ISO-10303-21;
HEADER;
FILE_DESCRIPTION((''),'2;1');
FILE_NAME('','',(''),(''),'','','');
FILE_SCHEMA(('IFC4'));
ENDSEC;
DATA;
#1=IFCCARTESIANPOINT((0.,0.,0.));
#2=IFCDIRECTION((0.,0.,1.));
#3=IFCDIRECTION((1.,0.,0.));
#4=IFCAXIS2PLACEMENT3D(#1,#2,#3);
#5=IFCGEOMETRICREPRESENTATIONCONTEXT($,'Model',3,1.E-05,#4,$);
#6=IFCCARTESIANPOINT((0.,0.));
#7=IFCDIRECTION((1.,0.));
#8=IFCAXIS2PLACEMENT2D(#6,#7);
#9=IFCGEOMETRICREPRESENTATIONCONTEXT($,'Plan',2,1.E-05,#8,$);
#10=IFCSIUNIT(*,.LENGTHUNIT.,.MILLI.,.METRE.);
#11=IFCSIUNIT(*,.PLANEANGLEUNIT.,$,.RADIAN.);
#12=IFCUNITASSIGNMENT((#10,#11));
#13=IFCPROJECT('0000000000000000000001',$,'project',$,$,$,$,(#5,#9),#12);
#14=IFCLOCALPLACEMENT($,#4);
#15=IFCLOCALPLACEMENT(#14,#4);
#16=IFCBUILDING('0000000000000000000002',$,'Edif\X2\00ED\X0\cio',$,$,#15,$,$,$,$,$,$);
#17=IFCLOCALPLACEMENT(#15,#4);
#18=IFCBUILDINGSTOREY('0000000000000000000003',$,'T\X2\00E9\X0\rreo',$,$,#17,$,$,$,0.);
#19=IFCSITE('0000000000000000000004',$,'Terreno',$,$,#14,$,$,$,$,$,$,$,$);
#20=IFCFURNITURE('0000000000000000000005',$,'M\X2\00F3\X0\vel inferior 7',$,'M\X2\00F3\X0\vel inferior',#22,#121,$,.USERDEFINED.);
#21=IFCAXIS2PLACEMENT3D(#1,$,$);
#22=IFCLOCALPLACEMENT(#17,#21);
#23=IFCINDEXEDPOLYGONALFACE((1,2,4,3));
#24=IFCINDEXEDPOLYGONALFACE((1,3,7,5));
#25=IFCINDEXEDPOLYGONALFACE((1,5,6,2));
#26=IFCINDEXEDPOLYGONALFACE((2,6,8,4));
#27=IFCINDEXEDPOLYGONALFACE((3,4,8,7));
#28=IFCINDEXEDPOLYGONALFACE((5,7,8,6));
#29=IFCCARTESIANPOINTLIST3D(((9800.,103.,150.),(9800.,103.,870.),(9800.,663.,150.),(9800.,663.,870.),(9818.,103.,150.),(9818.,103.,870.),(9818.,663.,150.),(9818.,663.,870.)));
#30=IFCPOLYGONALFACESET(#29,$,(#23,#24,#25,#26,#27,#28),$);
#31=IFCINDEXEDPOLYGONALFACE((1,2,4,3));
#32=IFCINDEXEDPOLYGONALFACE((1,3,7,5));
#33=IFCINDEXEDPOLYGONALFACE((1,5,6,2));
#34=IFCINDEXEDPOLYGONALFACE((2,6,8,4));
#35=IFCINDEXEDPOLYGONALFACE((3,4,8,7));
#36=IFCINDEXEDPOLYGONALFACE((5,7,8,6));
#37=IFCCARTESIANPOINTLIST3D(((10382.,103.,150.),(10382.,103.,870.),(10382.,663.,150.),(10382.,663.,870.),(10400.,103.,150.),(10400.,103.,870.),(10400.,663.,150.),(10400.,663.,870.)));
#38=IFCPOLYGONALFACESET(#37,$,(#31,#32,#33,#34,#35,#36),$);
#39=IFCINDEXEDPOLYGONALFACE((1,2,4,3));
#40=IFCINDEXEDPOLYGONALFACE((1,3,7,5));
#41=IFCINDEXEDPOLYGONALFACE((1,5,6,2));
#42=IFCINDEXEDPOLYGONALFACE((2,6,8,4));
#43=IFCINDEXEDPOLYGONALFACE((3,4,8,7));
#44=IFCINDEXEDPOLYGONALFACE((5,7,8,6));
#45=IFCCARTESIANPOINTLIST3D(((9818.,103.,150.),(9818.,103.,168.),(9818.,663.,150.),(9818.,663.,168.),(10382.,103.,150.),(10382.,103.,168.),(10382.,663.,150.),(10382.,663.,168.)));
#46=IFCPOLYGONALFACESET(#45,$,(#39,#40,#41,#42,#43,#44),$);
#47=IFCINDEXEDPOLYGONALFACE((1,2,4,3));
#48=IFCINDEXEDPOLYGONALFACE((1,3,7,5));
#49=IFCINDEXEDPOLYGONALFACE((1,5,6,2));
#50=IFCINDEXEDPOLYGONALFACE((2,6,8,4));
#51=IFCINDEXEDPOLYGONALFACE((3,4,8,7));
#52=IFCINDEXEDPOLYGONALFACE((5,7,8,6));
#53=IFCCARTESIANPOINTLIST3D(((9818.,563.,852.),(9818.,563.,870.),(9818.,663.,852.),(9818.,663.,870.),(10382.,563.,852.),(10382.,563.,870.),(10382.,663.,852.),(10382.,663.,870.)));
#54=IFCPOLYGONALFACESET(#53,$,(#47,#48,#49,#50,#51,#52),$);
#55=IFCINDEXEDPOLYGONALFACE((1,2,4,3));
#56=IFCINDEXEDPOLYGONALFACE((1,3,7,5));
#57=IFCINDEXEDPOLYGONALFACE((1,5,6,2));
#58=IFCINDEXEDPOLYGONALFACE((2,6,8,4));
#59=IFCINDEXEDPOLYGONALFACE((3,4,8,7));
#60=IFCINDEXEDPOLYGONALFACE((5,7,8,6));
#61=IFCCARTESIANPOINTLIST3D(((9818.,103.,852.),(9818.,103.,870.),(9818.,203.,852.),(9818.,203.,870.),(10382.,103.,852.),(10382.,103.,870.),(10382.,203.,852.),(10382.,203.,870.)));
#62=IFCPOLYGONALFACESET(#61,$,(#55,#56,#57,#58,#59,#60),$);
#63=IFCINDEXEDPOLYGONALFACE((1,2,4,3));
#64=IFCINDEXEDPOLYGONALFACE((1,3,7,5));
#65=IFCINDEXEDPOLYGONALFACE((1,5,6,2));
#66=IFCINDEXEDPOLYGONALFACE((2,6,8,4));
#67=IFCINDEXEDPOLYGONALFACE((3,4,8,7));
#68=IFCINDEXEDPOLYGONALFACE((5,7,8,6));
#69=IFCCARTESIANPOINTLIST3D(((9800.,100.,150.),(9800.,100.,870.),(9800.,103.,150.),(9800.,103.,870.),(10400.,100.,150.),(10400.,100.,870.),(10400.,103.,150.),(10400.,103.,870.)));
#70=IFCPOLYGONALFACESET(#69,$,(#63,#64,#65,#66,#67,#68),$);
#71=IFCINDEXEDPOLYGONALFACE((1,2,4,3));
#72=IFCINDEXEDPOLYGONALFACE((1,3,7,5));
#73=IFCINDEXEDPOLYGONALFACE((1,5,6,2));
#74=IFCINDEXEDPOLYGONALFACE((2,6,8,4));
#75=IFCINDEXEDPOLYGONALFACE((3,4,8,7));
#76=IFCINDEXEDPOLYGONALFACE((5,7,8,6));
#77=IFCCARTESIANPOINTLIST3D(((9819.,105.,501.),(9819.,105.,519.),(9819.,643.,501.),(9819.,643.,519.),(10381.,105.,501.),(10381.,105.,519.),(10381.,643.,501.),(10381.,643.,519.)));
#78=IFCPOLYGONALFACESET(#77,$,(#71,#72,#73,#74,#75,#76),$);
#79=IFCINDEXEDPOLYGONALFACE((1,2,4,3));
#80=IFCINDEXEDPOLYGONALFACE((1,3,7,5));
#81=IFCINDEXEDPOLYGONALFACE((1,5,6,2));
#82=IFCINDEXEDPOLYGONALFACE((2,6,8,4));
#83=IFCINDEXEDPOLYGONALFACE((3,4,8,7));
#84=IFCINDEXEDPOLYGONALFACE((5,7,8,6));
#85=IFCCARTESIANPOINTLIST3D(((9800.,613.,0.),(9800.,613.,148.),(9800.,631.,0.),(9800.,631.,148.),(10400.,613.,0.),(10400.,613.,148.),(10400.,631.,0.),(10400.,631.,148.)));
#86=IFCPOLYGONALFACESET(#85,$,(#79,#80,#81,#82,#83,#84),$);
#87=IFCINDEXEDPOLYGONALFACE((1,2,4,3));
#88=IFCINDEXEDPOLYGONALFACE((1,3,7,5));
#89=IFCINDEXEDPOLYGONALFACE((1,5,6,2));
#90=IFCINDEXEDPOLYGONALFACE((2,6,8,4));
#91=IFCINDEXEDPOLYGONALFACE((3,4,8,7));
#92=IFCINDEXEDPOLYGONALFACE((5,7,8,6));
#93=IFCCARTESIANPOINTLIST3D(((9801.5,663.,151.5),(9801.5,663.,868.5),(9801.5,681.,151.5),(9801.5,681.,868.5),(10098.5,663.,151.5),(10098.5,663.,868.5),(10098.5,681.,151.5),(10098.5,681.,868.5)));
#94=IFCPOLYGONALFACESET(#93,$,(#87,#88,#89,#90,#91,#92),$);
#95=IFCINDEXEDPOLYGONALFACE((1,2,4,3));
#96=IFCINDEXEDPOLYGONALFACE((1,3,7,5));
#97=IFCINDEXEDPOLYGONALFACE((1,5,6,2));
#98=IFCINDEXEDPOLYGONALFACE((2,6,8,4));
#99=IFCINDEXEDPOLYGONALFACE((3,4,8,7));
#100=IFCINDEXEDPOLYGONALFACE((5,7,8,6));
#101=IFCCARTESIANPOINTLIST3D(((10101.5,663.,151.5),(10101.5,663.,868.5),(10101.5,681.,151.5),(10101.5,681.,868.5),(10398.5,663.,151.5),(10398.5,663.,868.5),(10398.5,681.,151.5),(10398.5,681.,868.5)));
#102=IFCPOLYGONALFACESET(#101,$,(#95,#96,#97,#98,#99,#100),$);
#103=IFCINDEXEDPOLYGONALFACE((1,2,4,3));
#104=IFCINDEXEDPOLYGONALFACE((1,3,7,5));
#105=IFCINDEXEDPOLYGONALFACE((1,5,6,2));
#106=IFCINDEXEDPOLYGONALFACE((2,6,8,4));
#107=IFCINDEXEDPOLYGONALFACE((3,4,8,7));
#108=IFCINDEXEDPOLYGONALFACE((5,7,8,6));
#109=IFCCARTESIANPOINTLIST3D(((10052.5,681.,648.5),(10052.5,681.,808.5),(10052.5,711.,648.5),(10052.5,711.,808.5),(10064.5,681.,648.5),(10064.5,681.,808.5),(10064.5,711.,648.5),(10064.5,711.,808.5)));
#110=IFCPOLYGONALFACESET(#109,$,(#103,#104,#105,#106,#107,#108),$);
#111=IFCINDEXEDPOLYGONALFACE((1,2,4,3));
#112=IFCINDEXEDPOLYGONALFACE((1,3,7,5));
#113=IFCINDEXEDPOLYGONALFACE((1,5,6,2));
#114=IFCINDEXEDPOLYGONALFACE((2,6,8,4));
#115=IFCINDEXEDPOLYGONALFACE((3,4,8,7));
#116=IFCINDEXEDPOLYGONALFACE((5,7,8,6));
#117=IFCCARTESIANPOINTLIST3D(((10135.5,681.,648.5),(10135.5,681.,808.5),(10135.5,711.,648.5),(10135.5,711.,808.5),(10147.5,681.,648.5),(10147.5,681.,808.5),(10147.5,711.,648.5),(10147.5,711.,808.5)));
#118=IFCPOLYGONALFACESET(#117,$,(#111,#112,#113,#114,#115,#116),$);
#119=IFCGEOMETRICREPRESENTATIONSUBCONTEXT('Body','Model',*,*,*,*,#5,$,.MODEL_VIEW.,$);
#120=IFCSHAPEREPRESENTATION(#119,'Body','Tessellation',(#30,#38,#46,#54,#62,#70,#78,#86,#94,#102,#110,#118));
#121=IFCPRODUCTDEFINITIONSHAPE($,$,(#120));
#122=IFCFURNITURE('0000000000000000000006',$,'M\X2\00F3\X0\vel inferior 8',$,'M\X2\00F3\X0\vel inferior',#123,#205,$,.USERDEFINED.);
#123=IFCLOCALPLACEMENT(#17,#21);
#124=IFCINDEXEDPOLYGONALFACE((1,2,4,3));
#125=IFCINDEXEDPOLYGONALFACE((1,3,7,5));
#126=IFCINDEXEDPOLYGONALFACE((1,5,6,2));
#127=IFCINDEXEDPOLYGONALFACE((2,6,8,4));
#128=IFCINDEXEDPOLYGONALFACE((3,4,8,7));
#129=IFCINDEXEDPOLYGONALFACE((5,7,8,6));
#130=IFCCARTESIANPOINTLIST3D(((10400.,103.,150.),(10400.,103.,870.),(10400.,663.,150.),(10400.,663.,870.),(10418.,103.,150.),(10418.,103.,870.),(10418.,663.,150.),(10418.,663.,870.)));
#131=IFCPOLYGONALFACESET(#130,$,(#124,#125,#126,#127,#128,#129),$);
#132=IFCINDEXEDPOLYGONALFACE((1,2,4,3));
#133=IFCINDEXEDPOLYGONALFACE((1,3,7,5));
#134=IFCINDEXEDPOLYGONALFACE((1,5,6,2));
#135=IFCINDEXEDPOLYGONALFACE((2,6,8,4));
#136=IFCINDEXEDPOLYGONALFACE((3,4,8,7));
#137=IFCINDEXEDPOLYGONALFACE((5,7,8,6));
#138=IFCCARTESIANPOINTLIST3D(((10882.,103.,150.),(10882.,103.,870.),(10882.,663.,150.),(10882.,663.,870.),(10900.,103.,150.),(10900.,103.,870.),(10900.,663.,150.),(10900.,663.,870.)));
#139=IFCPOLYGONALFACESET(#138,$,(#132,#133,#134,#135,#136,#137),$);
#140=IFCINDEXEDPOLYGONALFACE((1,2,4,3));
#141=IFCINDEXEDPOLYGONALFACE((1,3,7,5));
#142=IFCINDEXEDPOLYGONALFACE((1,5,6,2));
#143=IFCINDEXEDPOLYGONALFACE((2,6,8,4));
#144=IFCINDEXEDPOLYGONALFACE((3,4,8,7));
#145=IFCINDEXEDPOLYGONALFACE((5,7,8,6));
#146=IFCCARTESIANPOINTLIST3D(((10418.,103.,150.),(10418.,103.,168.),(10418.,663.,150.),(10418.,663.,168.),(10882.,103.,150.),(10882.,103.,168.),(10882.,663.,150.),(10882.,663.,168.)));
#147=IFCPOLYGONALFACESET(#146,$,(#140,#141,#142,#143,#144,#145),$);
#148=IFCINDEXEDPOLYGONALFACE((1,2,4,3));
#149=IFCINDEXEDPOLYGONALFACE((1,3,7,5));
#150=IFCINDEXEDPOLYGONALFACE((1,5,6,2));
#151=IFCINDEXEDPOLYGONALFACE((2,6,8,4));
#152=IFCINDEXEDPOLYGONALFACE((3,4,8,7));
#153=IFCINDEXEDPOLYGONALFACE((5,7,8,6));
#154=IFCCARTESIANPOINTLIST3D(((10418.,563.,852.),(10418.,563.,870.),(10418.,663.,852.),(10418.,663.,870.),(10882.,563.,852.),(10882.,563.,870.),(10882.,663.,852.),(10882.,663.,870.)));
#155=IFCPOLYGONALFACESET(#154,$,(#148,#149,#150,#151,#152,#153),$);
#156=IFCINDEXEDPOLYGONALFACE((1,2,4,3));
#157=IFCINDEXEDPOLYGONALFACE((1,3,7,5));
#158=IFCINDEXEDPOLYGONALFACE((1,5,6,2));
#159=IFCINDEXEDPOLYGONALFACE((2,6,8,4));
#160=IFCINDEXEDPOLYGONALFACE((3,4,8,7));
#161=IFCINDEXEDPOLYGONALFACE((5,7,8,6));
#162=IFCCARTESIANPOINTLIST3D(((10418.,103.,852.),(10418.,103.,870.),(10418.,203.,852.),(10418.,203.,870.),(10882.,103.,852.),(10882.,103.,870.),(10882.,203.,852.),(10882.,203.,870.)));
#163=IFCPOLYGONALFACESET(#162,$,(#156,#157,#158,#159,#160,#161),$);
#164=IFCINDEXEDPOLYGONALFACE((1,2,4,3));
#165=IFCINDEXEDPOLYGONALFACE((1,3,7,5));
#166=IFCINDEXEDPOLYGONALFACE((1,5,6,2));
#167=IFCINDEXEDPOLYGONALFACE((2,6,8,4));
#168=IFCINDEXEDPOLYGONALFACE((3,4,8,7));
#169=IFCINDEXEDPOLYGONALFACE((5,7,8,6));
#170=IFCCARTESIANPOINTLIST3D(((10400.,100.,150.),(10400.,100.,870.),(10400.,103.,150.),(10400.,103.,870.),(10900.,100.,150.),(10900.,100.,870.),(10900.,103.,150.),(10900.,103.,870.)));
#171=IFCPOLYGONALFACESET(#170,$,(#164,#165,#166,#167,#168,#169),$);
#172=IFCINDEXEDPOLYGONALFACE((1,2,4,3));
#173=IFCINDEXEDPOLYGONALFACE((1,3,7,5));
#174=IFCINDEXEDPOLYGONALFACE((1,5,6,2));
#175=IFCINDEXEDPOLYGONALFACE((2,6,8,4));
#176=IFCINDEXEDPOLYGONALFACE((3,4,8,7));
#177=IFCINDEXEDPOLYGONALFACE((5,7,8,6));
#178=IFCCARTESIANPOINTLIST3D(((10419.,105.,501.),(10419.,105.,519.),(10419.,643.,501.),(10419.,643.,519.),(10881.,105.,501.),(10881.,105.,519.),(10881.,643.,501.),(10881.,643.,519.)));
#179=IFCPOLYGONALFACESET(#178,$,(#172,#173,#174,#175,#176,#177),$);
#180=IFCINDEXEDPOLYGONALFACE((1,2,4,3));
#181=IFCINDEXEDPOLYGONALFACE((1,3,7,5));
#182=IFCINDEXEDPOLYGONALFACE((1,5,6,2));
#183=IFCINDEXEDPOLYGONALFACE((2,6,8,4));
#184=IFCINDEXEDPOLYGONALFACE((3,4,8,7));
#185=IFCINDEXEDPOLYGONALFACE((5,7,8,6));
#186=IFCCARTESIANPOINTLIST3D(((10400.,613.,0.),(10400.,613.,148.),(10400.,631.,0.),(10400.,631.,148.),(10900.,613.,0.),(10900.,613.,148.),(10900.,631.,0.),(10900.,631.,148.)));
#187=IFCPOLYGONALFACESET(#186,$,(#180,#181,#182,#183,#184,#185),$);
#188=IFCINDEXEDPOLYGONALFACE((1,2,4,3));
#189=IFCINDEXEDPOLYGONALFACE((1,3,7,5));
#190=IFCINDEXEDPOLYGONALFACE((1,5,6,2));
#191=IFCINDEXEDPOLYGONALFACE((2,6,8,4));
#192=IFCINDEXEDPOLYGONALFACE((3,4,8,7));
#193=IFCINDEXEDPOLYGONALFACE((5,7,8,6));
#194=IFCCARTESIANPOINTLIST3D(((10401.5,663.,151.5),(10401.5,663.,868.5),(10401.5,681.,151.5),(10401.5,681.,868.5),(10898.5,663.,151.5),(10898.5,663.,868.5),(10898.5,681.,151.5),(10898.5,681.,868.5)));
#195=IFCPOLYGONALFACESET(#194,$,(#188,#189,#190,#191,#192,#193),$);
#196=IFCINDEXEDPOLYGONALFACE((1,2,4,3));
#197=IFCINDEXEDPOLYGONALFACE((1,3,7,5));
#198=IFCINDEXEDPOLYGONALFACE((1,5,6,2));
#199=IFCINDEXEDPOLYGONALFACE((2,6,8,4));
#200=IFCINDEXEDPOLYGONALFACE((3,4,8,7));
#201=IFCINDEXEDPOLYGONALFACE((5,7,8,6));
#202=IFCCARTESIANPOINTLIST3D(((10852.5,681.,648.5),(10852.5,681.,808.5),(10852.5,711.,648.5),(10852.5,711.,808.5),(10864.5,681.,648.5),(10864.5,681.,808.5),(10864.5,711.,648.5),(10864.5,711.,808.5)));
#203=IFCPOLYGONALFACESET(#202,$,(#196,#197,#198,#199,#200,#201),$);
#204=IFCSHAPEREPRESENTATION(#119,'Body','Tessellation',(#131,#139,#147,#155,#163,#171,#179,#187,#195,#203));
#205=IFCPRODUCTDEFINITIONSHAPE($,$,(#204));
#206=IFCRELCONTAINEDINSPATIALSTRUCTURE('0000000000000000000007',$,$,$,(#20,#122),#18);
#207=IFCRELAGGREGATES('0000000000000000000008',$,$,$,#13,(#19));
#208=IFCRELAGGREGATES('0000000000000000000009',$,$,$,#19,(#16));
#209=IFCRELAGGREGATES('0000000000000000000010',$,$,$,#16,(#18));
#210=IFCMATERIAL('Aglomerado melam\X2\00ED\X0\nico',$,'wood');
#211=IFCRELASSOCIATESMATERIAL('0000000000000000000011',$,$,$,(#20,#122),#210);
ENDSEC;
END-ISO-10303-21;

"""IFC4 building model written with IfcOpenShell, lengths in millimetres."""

from ifc_helpers import new_model, si_unit, frame, frame_2d, origin, origin_with_axes, origin_2d_with_axis, place, context, subcontext, project, spatial, rectangle, extrude, material, element, save


model = new_model("IFC4")

# Units and contexts
model_context = context("Model", 3, precision=1e-05, world=origin_with_axes())
plan_context = context("Plan", 2, precision=1e-05, world=origin_2d_with_axis())
body_context = subcontext(model_context, "Body", "Model", "MODEL_VIEW")
ifc_project = project(units=[si_unit("LENGTHUNIT", "METRE", prefix="MILLI"), si_unit("PLANEANGLEUNIT", "RADIAN")], contexts=[model_context, plan_context])

# Site, building, storey
site_placement = place(None, origin_with_axes())
site = spatial("IfcSite", under=ifc_project, at=site_placement, Name="Terreno")
building_placement = place(site_placement, origin_with_axes())
building = spatial("IfcBuilding", under=site, at=building_placement, Name="Edifício")
storey_placement = place(building_placement, origin_with_axes())
storey = spatial("IfcBuildingStorey", under=building, at=storey_placement, Name="Térreo", Elevation=0.0)

# Furniture
ifc_material_1 = material(Name="Aglomerado melamínico", Category="wood")
furniture_1_placement = place(storey_placement, frame((9800.0, 100.0, 0.0), z_axis=(0.0, 0.0, 1.0), x_axis=(1.0, 0.0, 0.0)))
element("IfcFurniture", 1, at=furniture_1_placement, inside=storey, material=ifc_material_1, Name="Móvel inferior 7", ObjectType="Móvel inferior", PredefinedType="USERDEFINED", context=body_context, shape_type="SweptSolid", body=[
    extrude(rectangle(XDim=18.0, YDim=560.0, at=frame_2d((9.0, 283.0))), frame((0.0, 0.0, 150.0)), (0.0, 0.0, 1.0), 720.0),
    extrude(rectangle(XDim=18.0, YDim=560.0, at=frame_2d((591.0, 283.0))), frame((0.0, 0.0, 150.0)), (0.0, 0.0, 1.0), 720.0),
    extrude(rectangle(XDim=564.0, YDim=560.0, at=frame_2d((300.0, 283.0))), frame((0.0, 0.0, 150.0)), (0.0, 0.0, 1.0), 18.0),
    extrude(rectangle(XDim=564.0, YDim=100.0, at=frame_2d((300.0, 513.0))), frame((0.0, 0.0, 852.0)), (0.0, 0.0, 1.0), 18.0),
    extrude(rectangle(XDim=564.0, YDim=100.0, at=frame_2d((300.0, 53.0))), frame((0.0, 0.0, 852.0)), (0.0, 0.0, 1.0), 18.0),
    extrude(rectangle(XDim=600.0, YDim=3.0, at=frame_2d((300.0, 1.5))), frame((0.0, 0.0, 150.0)), (0.0, 0.0, 1.0), 720.0),
    extrude(rectangle(XDim=562.0, YDim=538.0, at=frame_2d((300.0, 274.0))), frame((0.0, 0.0, 501.0)), (0.0, 0.0, 1.0), 18.0),
    extrude(rectangle(XDim=600.0, YDim=18.0, at=frame_2d((300.0, 522.0))), origin(), (0.0, 0.0, 1.0), 148.0),
    extrude(rectangle(XDim=297.0, YDim=18.0, at=frame_2d((150.0, 572.0))), frame((0.0, 0.0, 151.5)), (0.0, 0.0, 1.0), 717.0),
    extrude(rectangle(XDim=297.0, YDim=18.0, at=frame_2d((450.0, 572.0))), frame((0.0, 0.0, 151.5)), (0.0, 0.0, 1.0), 717.0),
    extrude(rectangle(XDim=12.0, YDim=30.0, at=frame_2d((258.5, 596.0))), frame((0.0, 0.0, 648.5)), (0.0, 0.0, 1.0), 160.0),
    extrude(rectangle(XDim=12.0, YDim=30.0, at=frame_2d((341.5, 596.0))), frame((0.0, 0.0, 648.5)), (0.0, 0.0, 1.0), 160.0),
])
furniture_2_placement = place(storey_placement, frame((10400.0, 100.0, 0.0), z_axis=(0.0, 0.0, 1.0), x_axis=(1.0, 0.0, 0.0)))
element("IfcFurniture", 2, at=furniture_2_placement, inside=storey, material=ifc_material_1, Name="Móvel inferior 8", ObjectType="Móvel inferior", PredefinedType="USERDEFINED", context=body_context, shape_type="SweptSolid", body=[
    extrude(rectangle(XDim=18.0, YDim=560.0, at=frame_2d((9.0, 283.0))), frame((0.0, 0.0, 150.0)), (0.0, 0.0, 1.0), 720.0),
    extrude(rectangle(XDim=18.0, YDim=560.0, at=frame_2d((491.0, 283.0))), frame((0.0, 0.0, 150.0)), (0.0, 0.0, 1.0), 720.0),
    extrude(rectangle(XDim=464.0, YDim=560.0, at=frame_2d((250.0, 283.0))), frame((0.0, 0.0, 150.0)), (0.0, 0.0, 1.0), 18.0),
    extrude(rectangle(XDim=464.0, YDim=100.0, at=frame_2d((250.0, 513.0))), frame((0.0, 0.0, 852.0)), (0.0, 0.0, 1.0), 18.0),
    extrude(rectangle(XDim=464.0, YDim=100.0, at=frame_2d((250.0, 53.0))), frame((0.0, 0.0, 852.0)), (0.0, 0.0, 1.0), 18.0),
    extrude(rectangle(XDim=500.0, YDim=3.0, at=frame_2d((250.0, 1.5))), frame((0.0, 0.0, 150.0)), (0.0, 0.0, 1.0), 720.0),
    extrude(rectangle(XDim=462.0, YDim=538.0, at=frame_2d((250.0, 274.0))), frame((0.0, 0.0, 501.0)), (0.0, 0.0, 1.0), 18.0),
    extrude(rectangle(XDim=500.0, YDim=18.0, at=frame_2d((250.0, 522.0))), origin(), (0.0, 0.0, 1.0), 148.0),
    extrude(rectangle(XDim=497.0, YDim=18.0, at=frame_2d((250.0, 572.0))), frame((0.0, 0.0, 151.5)), (0.0, 0.0, 1.0), 717.0),
    extrude(rectangle(XDim=12.0, YDim=30.0, at=frame_2d((458.5, 596.0))), frame((0.0, 0.0, 648.5)), (0.0, 0.0, 1.0), 160.0),
])

save(model, "model.ifc")
